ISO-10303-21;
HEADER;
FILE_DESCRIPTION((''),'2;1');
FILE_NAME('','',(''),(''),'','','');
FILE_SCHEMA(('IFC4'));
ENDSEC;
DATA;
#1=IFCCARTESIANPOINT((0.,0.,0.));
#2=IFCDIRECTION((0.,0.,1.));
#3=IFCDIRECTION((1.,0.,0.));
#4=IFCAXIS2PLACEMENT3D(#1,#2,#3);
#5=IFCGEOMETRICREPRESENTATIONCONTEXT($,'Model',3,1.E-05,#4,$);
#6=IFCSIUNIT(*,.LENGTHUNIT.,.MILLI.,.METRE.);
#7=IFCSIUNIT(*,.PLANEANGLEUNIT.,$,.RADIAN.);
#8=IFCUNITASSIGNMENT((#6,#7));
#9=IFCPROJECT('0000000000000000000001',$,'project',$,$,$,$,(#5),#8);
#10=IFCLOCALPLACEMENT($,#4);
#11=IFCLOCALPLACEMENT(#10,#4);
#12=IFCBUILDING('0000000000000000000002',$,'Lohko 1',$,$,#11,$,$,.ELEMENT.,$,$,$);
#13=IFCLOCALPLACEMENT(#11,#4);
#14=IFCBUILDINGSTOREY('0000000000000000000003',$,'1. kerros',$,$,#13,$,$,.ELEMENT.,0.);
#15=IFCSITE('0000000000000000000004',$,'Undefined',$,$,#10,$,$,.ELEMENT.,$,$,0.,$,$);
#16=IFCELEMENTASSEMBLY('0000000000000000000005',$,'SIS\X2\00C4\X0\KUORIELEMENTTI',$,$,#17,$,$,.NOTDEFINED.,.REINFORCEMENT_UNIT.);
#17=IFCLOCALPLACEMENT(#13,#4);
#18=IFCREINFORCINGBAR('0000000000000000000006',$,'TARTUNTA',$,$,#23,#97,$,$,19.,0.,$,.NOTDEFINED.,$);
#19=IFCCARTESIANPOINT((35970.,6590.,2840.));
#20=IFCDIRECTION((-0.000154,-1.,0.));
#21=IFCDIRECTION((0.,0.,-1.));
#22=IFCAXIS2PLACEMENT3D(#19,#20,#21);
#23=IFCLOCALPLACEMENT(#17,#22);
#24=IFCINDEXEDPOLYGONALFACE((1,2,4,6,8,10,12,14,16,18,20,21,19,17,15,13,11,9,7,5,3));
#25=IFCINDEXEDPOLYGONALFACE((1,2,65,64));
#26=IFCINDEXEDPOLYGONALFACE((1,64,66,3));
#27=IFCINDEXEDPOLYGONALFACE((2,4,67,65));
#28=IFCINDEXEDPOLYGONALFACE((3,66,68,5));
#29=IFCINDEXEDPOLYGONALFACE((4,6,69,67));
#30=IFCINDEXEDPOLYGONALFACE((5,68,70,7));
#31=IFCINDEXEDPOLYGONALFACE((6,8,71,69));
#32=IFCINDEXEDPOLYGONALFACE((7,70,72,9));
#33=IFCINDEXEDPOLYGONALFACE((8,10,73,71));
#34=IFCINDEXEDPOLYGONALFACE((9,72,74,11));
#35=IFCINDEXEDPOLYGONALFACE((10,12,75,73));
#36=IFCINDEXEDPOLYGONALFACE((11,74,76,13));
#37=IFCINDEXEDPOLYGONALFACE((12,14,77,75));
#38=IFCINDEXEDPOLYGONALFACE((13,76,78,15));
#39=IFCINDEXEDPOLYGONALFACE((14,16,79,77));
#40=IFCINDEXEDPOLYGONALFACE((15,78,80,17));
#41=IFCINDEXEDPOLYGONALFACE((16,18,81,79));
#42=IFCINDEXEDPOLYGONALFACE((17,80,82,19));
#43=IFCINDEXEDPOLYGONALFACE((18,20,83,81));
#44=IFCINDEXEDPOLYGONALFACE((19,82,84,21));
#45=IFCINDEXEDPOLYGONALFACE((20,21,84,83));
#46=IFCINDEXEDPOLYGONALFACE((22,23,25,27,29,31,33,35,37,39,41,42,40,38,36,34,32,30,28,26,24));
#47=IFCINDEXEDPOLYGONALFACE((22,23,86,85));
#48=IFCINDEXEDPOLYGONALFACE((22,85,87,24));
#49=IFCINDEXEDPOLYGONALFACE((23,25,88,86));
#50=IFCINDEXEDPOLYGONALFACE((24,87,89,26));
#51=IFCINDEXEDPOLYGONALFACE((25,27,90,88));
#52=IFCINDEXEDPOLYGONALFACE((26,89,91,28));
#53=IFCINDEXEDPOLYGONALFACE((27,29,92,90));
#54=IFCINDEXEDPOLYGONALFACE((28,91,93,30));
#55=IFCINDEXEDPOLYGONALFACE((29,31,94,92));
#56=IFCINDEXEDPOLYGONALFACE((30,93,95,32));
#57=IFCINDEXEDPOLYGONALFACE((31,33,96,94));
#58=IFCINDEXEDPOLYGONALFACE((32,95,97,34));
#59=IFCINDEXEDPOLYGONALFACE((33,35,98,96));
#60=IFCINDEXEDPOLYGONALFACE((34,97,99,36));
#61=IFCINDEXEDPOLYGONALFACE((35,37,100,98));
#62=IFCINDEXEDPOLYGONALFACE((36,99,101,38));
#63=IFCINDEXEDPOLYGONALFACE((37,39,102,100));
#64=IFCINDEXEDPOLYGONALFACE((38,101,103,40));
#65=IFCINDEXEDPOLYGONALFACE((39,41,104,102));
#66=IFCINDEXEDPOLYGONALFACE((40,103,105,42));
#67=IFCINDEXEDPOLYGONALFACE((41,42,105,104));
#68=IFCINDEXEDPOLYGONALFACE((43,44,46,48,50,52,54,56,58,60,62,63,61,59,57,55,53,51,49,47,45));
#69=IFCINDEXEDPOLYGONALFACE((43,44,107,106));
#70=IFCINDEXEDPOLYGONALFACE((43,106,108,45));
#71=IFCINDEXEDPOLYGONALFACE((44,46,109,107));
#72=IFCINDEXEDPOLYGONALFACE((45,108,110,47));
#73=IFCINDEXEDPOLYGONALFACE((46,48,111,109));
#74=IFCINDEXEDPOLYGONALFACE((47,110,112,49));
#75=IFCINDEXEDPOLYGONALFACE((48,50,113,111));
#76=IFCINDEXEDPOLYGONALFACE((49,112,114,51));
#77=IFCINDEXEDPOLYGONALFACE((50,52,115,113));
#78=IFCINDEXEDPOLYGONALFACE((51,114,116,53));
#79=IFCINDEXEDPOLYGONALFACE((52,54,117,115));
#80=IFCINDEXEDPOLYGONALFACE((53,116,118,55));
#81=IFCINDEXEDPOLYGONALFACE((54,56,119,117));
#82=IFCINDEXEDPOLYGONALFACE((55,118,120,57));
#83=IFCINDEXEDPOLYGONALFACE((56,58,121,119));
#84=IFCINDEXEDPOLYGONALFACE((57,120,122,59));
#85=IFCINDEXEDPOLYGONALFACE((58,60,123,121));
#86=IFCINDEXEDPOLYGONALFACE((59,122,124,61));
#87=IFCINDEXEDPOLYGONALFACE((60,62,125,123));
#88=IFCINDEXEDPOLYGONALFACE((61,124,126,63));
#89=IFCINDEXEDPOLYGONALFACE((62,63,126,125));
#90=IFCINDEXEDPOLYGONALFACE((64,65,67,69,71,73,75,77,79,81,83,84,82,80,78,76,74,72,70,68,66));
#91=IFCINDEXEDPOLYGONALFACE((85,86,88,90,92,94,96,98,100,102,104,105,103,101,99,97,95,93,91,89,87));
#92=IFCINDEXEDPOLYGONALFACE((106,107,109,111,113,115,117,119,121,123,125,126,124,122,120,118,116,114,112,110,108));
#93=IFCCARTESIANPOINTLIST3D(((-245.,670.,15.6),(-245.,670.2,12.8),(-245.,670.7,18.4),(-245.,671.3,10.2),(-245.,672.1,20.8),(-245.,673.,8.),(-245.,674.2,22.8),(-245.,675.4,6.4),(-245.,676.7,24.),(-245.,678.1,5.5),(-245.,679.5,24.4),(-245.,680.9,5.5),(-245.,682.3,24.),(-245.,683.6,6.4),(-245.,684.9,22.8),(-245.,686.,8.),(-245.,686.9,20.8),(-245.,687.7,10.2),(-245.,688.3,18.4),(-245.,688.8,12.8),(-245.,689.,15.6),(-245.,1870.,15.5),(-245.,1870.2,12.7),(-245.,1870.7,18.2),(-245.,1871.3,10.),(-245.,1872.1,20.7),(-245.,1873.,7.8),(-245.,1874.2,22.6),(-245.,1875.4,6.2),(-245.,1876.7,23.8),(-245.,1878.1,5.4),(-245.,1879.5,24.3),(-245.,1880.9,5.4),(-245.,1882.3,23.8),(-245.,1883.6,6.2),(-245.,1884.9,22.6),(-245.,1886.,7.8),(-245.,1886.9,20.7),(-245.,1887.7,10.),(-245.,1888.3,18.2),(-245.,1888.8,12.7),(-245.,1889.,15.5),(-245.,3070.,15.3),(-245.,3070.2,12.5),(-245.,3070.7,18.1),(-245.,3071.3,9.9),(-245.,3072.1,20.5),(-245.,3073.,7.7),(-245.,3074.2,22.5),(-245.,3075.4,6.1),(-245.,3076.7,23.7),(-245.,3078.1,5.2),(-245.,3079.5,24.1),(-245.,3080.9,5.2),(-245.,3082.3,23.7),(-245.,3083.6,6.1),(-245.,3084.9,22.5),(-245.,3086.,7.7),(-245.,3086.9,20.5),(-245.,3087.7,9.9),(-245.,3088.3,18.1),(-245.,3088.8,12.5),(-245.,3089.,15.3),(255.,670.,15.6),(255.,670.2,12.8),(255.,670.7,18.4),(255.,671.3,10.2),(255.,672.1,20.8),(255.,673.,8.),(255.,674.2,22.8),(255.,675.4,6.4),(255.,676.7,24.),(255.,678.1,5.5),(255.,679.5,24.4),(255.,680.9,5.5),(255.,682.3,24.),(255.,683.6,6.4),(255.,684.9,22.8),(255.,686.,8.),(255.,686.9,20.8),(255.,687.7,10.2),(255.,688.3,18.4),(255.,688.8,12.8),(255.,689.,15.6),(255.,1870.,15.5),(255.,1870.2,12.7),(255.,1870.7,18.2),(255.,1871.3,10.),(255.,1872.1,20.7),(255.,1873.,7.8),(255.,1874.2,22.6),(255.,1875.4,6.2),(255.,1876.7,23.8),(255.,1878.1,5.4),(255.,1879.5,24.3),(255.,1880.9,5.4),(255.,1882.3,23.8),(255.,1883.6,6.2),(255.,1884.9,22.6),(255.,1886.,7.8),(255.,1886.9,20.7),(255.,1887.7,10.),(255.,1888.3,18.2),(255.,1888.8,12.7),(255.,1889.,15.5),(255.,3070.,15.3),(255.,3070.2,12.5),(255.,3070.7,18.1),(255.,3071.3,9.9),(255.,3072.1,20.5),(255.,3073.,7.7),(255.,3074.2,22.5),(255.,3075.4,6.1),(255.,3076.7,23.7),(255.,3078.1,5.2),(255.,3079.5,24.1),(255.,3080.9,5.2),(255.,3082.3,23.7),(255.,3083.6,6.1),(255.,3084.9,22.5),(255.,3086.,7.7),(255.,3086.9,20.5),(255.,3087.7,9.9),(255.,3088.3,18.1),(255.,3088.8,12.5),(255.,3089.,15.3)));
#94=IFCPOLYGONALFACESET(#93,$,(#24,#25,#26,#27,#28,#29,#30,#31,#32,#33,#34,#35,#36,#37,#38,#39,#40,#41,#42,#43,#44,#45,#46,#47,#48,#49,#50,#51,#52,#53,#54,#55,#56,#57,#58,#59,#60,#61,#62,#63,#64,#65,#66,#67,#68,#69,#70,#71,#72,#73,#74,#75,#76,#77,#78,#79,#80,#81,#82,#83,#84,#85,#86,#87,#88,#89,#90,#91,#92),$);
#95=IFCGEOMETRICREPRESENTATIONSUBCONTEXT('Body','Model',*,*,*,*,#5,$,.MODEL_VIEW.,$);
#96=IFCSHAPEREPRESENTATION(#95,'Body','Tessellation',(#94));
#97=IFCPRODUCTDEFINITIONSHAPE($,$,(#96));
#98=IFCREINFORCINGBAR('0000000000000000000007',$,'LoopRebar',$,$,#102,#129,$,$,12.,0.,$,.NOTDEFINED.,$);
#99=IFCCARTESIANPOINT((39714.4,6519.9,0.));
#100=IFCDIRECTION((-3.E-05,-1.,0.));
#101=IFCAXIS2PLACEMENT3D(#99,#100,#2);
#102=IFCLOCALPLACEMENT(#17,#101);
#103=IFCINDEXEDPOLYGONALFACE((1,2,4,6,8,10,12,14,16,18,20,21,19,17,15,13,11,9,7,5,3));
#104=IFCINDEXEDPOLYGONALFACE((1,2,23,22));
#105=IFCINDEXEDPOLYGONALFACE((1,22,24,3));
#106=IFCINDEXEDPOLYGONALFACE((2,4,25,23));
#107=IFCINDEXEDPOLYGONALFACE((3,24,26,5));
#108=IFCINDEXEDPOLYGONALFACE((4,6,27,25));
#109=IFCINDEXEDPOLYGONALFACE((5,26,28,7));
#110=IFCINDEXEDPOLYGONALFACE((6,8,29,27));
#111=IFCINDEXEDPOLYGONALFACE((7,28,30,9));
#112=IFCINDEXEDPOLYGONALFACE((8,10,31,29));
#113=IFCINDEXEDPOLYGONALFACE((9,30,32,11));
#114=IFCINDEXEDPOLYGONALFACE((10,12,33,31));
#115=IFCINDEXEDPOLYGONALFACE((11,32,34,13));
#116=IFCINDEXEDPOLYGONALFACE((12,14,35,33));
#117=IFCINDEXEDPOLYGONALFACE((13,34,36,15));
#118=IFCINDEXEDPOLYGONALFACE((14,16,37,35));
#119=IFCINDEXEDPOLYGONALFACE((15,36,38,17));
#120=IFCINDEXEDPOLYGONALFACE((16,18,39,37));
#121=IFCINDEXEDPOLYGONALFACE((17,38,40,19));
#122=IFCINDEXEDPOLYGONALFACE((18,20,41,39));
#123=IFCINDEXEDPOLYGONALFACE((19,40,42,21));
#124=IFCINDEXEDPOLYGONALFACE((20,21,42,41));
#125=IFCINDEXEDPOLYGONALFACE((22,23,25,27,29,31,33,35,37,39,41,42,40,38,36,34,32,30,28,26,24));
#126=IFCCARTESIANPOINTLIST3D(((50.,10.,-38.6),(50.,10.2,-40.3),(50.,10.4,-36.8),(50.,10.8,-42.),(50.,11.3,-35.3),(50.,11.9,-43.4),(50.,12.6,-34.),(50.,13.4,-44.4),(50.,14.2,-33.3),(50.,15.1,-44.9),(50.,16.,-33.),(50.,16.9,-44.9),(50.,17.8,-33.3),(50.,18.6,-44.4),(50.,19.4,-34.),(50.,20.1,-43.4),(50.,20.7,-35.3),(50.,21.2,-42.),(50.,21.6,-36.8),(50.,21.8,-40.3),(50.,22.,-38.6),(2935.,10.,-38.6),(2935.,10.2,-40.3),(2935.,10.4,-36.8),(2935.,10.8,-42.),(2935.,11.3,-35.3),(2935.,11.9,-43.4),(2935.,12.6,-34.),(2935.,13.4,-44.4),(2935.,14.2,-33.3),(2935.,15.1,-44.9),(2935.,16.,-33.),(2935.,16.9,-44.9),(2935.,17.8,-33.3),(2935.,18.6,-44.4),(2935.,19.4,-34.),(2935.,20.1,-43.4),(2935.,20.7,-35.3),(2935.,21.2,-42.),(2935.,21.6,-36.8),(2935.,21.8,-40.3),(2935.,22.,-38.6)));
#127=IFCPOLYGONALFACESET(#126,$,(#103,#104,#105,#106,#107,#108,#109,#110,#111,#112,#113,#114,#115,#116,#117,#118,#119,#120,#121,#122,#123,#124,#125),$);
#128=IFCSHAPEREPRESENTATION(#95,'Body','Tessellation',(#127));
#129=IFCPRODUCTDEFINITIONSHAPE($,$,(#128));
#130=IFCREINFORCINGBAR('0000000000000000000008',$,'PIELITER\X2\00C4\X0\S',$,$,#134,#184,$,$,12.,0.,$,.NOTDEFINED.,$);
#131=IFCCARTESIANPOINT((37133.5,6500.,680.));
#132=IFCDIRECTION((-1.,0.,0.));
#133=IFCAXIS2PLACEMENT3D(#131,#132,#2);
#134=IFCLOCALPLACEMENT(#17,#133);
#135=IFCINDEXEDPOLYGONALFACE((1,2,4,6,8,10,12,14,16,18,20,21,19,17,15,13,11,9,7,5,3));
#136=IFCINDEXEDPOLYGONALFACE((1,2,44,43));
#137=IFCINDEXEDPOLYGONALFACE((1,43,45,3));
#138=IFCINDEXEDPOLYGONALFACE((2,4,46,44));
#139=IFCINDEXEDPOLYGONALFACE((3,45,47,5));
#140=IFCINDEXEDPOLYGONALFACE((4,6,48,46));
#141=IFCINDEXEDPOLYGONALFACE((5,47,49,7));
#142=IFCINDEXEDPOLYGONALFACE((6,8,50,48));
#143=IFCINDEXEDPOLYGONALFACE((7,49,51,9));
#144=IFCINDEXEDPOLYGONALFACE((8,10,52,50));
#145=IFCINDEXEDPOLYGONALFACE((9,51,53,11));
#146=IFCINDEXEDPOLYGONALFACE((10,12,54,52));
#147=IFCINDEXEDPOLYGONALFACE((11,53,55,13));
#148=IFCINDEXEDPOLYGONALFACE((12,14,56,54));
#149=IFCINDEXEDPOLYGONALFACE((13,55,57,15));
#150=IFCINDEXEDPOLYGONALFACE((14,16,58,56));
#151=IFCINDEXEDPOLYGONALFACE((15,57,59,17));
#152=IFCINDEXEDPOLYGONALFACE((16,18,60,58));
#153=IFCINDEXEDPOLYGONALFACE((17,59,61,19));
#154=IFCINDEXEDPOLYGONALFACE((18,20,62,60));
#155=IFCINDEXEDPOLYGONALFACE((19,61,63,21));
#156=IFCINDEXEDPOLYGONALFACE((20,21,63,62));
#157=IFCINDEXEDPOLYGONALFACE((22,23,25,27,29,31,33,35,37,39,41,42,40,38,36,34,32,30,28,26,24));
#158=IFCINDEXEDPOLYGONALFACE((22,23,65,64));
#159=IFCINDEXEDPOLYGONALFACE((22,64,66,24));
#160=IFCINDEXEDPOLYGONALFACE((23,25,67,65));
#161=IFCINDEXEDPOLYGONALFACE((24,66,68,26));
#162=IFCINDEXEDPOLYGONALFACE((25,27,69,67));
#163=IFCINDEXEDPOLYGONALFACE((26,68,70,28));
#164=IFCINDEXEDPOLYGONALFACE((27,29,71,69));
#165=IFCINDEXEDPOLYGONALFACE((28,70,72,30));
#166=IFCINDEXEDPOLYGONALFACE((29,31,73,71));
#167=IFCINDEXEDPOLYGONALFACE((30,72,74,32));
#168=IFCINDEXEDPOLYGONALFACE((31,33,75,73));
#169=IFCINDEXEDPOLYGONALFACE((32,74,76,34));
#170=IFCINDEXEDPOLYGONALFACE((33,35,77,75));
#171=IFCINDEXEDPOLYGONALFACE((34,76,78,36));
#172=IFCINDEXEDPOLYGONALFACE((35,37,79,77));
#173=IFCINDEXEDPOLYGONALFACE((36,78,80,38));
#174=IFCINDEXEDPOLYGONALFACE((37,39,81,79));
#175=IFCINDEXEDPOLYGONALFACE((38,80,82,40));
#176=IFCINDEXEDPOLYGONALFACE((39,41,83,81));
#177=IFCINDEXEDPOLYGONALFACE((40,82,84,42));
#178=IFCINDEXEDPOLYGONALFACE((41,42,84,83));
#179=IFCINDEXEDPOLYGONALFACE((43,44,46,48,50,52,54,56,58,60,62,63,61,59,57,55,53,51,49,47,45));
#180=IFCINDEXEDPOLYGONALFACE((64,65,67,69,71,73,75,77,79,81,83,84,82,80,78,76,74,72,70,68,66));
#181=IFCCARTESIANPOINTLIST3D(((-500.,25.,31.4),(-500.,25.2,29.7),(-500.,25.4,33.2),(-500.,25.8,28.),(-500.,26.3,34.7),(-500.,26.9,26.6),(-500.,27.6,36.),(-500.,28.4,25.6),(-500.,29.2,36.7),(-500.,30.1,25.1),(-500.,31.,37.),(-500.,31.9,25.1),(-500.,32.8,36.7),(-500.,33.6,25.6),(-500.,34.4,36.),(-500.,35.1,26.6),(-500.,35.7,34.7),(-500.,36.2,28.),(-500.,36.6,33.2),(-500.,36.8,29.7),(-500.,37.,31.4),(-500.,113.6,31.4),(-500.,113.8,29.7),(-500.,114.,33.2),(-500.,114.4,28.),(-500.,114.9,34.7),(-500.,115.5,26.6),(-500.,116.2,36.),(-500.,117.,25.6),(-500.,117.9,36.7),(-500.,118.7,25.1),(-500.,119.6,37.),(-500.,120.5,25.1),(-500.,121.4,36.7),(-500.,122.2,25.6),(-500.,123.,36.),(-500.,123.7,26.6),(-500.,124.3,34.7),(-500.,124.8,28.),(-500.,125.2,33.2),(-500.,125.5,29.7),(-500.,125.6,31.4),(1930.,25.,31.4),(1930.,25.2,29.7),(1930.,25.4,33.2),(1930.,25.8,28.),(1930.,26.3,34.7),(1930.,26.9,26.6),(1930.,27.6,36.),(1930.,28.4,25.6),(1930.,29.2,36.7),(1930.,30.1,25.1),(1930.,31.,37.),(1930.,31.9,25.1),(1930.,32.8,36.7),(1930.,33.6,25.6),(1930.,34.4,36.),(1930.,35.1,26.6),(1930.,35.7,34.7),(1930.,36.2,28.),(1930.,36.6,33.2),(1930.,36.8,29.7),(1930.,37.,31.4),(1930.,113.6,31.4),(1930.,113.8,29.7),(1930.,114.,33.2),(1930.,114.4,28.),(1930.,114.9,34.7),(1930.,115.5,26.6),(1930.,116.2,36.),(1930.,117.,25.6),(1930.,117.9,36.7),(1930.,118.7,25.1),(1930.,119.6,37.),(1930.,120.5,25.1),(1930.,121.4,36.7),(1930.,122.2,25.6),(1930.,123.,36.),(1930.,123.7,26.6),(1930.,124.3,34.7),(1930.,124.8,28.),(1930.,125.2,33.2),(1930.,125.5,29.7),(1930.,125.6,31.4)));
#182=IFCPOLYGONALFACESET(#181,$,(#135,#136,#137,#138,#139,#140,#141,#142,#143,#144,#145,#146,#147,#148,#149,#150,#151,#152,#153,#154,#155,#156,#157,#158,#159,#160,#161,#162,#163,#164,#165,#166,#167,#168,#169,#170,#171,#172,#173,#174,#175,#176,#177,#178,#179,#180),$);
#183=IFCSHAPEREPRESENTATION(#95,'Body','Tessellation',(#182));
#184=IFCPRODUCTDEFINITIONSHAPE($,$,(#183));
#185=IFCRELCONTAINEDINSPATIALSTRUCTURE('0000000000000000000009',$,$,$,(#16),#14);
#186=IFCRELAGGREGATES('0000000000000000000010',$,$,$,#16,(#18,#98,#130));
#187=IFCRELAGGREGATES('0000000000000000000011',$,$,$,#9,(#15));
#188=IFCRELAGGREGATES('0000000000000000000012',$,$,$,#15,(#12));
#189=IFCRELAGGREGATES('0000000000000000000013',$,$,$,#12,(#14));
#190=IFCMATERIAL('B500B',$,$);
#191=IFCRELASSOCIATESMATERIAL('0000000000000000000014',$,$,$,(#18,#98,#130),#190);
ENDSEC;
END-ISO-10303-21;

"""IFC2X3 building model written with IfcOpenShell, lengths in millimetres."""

from ifc_helpers import new_model, entity, si_unit, frame, origin_with_axes, place, context, subcontext, project, spatial, source, transform, mapped, material, element, aggregate, save


model = new_model("IFC2X3")

# Units and contexts
model_context = context("Model", 3, precision=1e-05, world=origin_with_axes())
body_context = subcontext(model_context, "Body", "Model", "MODEL_VIEW")
ifc_project = project(units=[si_unit("LENGTHUNIT", "METRE", prefix="MILLI"), si_unit("PLANEANGLEUNIT", "RADIAN")], contexts=[model_context])

# Site, building, storey
site_placement = place(None, origin_with_axes())
site = spatial("IfcSite", under=ifc_project, at=site_placement, Name="Undefined", CompositionType="ELEMENT", RefElevation=0.0)
building_placement = place(site_placement, origin_with_axes())
building = spatial("IfcBuilding", under=site, at=building_placement, Name="Lohko 1", CompositionType="ELEMENT")
storey_placement = place(building_placement, origin_with_axes())
storey = spatial("IfcBuildingStorey", under=building, at=storey_placement, Name="1. kerros", CompositionType="ELEMENT", Elevation=0.0)

# Element assembly, reinforcing bars
assembly_placement = place(storey_placement, origin_with_axes())
assembly = element("IfcElementAssembly", 1, at=assembly_placement, inside=storey, Name="SISÄKUORIELEMENTTI", AssemblyPlace="NOTDEFINED", PredefinedType="REINFORCEMENT_UNIT")
ifc_material = material(Name="B500B")
shared_shape_1 = source(origin_with_axes(), body_context, "Body", "AdvancedSweptSolid", [
    entity("IfcSweptDiskSolid", entity("IfcTrimmedCurve", entity("IfcLine", entity("IfcCartesianPoint", [0.0, 0.0, 0.0]), entity("IfcVector", entity("IfcDirection", [1.0, 0.0, 0.0]), 1.0)), [entity("IfcParameterValue", 0.0)], [entity("IfcParameterValue", 500.0)], True, "PARAMETER"), 9.5, None, 0.0, 500.0),
])
shared_shape_2 = source(origin_with_axes(), body_context, "Body", "AdvancedSweptSolid", [
    entity("IfcSweptDiskSolid", entity("IfcTrimmedCurve", entity("IfcLine", entity("IfcCartesianPoint", [0.0, 0.0, 0.0]), entity("IfcVector", entity("IfcDirection", [1.0, 0.0, 0.0]), 1.0)), [entity("IfcParameterValue", 0.0)], [entity("IfcParameterValue", 500.0)], True, "PARAMETER"), 9.5, None, 0.0, 500.0),
])
shared_shape_3 = source(origin_with_axes(), body_context, "Body", "AdvancedSweptSolid", [
    entity("IfcSweptDiskSolid", entity("IfcTrimmedCurve", entity("IfcLine", entity("IfcCartesianPoint", [0.0, 0.0, 0.0]), entity("IfcVector", entity("IfcDirection", [1.0, 0.0, 0.0]), 1.0)), [entity("IfcParameterValue", 0.0)], [entity("IfcParameterValue", 500.0)], True, "PARAMETER"), 9.5, None, 0.0, 500.0),
])
reinforcing_bar_1_placement = place(assembly_placement, frame((35970.0, 6590.0, 2840.0), z_axis=(-0.000154, -1.0, 0.0), x_axis=(0.0, 0.0, -1.0)))
reinforcing_bar_1 = element("IfcReinforcingBar", 2, at=reinforcing_bar_1_placement, material=ifc_material, Name="TARTUNTA", BarRole="NOTDEFINED", CrossSectionArea=0.0, NominalDiameter=19.0, context=body_context, shape_type="MappedRepresentation", body=[
    mapped(shared_shape_1, transform((-245.0, 679.5, 14.9))),
    mapped(shared_shape_2, transform((-245.0, 1879.5, 14.8))),
    mapped(shared_shape_3, transform((-245.0, 3079.5, 14.6))),
])
shared_shape_4 = source(origin_with_axes(), body_context, "Body", "AdvancedSweptSolid", [
    entity("IfcSweptDiskSolid", entity("IfcTrimmedCurve", entity("IfcLine", entity("IfcCartesianPoint", [0.0, 0.0, 0.0]), entity("IfcVector", entity("IfcDirection", [1.0, 0.0, 0.0]), 1.0)), [entity("IfcParameterValue", 0.0)], [entity("IfcParameterValue", 2885.0)], True, "PARAMETER"), 6.0, None, 0.0, 2885.0),
])
reinforcing_bar_2_placement = place(assembly_placement, frame((39714.4, 6519.9, 0.0), z_axis=(-0.00003, -1.0, 0.0), x_axis=(0.0, 0.0, 1.0)))
reinforcing_bar_2 = element("IfcReinforcingBar", 3, at=reinforcing_bar_2_placement, material=ifc_material, Name="LoopRebar", BarRole="NOTDEFINED", CrossSectionArea=0.0, NominalDiameter=12.0, context=body_context, shape_type="MappedRepresentation", body=[
    mapped(shared_shape_4, transform((50.0, 16.0, -39.0))),
])
shared_shape_5 = source(origin_with_axes(), body_context, "Body", "AdvancedSweptSolid", [
    entity("IfcSweptDiskSolid", entity("IfcTrimmedCurve", entity("IfcLine", entity("IfcCartesianPoint", [0.0, 0.0, 0.0]), entity("IfcVector", entity("IfcDirection", [1.0, 0.0, 0.0]), 1.0)), [entity("IfcParameterValue", 0.0)], [entity("IfcParameterValue", 2430.0)], True, "PARAMETER"), 6.0, None, 0.0, 2430.0),
])
shared_shape_6 = source(origin_with_axes(), body_context, "Body", "AdvancedSweptSolid", [
    entity("IfcSweptDiskSolid", entity("IfcTrimmedCurve", entity("IfcLine", entity("IfcCartesianPoint", [0.0, 0.0, 0.0]), entity("IfcVector", entity("IfcDirection", [1.0, 0.0, 0.0]), 1.0)), [entity("IfcParameterValue", 0.0)], [entity("IfcParameterValue", 2430.0)], True, "PARAMETER"), 6.0, None, 0.0, 2430.0),
])
reinforcing_bar_3_placement = place(assembly_placement, frame((37133.5, 6500.0, 680.0), z_axis=(-1.0, 0.0, 0.0), x_axis=(0.0, 0.0, 1.0)))
reinforcing_bar_3 = element("IfcReinforcingBar", 4, at=reinforcing_bar_3_placement, material=ifc_material, Name="PIELITERÄS", BarRole="NOTDEFINED", CrossSectionArea=0.0, NominalDiameter=12.0, context=body_context, shape_type="MappedRepresentation", body=[
    mapped(shared_shape_5, transform((-500.0, 31.0, 31.0))),
    mapped(shared_shape_6, transform((-500.0, 119.6, 31.0))),
])
aggregate(assembly, [reinforcing_bar_1, reinforcing_bar_2, reinforcing_bar_3])

save(model, "model.ifc")
